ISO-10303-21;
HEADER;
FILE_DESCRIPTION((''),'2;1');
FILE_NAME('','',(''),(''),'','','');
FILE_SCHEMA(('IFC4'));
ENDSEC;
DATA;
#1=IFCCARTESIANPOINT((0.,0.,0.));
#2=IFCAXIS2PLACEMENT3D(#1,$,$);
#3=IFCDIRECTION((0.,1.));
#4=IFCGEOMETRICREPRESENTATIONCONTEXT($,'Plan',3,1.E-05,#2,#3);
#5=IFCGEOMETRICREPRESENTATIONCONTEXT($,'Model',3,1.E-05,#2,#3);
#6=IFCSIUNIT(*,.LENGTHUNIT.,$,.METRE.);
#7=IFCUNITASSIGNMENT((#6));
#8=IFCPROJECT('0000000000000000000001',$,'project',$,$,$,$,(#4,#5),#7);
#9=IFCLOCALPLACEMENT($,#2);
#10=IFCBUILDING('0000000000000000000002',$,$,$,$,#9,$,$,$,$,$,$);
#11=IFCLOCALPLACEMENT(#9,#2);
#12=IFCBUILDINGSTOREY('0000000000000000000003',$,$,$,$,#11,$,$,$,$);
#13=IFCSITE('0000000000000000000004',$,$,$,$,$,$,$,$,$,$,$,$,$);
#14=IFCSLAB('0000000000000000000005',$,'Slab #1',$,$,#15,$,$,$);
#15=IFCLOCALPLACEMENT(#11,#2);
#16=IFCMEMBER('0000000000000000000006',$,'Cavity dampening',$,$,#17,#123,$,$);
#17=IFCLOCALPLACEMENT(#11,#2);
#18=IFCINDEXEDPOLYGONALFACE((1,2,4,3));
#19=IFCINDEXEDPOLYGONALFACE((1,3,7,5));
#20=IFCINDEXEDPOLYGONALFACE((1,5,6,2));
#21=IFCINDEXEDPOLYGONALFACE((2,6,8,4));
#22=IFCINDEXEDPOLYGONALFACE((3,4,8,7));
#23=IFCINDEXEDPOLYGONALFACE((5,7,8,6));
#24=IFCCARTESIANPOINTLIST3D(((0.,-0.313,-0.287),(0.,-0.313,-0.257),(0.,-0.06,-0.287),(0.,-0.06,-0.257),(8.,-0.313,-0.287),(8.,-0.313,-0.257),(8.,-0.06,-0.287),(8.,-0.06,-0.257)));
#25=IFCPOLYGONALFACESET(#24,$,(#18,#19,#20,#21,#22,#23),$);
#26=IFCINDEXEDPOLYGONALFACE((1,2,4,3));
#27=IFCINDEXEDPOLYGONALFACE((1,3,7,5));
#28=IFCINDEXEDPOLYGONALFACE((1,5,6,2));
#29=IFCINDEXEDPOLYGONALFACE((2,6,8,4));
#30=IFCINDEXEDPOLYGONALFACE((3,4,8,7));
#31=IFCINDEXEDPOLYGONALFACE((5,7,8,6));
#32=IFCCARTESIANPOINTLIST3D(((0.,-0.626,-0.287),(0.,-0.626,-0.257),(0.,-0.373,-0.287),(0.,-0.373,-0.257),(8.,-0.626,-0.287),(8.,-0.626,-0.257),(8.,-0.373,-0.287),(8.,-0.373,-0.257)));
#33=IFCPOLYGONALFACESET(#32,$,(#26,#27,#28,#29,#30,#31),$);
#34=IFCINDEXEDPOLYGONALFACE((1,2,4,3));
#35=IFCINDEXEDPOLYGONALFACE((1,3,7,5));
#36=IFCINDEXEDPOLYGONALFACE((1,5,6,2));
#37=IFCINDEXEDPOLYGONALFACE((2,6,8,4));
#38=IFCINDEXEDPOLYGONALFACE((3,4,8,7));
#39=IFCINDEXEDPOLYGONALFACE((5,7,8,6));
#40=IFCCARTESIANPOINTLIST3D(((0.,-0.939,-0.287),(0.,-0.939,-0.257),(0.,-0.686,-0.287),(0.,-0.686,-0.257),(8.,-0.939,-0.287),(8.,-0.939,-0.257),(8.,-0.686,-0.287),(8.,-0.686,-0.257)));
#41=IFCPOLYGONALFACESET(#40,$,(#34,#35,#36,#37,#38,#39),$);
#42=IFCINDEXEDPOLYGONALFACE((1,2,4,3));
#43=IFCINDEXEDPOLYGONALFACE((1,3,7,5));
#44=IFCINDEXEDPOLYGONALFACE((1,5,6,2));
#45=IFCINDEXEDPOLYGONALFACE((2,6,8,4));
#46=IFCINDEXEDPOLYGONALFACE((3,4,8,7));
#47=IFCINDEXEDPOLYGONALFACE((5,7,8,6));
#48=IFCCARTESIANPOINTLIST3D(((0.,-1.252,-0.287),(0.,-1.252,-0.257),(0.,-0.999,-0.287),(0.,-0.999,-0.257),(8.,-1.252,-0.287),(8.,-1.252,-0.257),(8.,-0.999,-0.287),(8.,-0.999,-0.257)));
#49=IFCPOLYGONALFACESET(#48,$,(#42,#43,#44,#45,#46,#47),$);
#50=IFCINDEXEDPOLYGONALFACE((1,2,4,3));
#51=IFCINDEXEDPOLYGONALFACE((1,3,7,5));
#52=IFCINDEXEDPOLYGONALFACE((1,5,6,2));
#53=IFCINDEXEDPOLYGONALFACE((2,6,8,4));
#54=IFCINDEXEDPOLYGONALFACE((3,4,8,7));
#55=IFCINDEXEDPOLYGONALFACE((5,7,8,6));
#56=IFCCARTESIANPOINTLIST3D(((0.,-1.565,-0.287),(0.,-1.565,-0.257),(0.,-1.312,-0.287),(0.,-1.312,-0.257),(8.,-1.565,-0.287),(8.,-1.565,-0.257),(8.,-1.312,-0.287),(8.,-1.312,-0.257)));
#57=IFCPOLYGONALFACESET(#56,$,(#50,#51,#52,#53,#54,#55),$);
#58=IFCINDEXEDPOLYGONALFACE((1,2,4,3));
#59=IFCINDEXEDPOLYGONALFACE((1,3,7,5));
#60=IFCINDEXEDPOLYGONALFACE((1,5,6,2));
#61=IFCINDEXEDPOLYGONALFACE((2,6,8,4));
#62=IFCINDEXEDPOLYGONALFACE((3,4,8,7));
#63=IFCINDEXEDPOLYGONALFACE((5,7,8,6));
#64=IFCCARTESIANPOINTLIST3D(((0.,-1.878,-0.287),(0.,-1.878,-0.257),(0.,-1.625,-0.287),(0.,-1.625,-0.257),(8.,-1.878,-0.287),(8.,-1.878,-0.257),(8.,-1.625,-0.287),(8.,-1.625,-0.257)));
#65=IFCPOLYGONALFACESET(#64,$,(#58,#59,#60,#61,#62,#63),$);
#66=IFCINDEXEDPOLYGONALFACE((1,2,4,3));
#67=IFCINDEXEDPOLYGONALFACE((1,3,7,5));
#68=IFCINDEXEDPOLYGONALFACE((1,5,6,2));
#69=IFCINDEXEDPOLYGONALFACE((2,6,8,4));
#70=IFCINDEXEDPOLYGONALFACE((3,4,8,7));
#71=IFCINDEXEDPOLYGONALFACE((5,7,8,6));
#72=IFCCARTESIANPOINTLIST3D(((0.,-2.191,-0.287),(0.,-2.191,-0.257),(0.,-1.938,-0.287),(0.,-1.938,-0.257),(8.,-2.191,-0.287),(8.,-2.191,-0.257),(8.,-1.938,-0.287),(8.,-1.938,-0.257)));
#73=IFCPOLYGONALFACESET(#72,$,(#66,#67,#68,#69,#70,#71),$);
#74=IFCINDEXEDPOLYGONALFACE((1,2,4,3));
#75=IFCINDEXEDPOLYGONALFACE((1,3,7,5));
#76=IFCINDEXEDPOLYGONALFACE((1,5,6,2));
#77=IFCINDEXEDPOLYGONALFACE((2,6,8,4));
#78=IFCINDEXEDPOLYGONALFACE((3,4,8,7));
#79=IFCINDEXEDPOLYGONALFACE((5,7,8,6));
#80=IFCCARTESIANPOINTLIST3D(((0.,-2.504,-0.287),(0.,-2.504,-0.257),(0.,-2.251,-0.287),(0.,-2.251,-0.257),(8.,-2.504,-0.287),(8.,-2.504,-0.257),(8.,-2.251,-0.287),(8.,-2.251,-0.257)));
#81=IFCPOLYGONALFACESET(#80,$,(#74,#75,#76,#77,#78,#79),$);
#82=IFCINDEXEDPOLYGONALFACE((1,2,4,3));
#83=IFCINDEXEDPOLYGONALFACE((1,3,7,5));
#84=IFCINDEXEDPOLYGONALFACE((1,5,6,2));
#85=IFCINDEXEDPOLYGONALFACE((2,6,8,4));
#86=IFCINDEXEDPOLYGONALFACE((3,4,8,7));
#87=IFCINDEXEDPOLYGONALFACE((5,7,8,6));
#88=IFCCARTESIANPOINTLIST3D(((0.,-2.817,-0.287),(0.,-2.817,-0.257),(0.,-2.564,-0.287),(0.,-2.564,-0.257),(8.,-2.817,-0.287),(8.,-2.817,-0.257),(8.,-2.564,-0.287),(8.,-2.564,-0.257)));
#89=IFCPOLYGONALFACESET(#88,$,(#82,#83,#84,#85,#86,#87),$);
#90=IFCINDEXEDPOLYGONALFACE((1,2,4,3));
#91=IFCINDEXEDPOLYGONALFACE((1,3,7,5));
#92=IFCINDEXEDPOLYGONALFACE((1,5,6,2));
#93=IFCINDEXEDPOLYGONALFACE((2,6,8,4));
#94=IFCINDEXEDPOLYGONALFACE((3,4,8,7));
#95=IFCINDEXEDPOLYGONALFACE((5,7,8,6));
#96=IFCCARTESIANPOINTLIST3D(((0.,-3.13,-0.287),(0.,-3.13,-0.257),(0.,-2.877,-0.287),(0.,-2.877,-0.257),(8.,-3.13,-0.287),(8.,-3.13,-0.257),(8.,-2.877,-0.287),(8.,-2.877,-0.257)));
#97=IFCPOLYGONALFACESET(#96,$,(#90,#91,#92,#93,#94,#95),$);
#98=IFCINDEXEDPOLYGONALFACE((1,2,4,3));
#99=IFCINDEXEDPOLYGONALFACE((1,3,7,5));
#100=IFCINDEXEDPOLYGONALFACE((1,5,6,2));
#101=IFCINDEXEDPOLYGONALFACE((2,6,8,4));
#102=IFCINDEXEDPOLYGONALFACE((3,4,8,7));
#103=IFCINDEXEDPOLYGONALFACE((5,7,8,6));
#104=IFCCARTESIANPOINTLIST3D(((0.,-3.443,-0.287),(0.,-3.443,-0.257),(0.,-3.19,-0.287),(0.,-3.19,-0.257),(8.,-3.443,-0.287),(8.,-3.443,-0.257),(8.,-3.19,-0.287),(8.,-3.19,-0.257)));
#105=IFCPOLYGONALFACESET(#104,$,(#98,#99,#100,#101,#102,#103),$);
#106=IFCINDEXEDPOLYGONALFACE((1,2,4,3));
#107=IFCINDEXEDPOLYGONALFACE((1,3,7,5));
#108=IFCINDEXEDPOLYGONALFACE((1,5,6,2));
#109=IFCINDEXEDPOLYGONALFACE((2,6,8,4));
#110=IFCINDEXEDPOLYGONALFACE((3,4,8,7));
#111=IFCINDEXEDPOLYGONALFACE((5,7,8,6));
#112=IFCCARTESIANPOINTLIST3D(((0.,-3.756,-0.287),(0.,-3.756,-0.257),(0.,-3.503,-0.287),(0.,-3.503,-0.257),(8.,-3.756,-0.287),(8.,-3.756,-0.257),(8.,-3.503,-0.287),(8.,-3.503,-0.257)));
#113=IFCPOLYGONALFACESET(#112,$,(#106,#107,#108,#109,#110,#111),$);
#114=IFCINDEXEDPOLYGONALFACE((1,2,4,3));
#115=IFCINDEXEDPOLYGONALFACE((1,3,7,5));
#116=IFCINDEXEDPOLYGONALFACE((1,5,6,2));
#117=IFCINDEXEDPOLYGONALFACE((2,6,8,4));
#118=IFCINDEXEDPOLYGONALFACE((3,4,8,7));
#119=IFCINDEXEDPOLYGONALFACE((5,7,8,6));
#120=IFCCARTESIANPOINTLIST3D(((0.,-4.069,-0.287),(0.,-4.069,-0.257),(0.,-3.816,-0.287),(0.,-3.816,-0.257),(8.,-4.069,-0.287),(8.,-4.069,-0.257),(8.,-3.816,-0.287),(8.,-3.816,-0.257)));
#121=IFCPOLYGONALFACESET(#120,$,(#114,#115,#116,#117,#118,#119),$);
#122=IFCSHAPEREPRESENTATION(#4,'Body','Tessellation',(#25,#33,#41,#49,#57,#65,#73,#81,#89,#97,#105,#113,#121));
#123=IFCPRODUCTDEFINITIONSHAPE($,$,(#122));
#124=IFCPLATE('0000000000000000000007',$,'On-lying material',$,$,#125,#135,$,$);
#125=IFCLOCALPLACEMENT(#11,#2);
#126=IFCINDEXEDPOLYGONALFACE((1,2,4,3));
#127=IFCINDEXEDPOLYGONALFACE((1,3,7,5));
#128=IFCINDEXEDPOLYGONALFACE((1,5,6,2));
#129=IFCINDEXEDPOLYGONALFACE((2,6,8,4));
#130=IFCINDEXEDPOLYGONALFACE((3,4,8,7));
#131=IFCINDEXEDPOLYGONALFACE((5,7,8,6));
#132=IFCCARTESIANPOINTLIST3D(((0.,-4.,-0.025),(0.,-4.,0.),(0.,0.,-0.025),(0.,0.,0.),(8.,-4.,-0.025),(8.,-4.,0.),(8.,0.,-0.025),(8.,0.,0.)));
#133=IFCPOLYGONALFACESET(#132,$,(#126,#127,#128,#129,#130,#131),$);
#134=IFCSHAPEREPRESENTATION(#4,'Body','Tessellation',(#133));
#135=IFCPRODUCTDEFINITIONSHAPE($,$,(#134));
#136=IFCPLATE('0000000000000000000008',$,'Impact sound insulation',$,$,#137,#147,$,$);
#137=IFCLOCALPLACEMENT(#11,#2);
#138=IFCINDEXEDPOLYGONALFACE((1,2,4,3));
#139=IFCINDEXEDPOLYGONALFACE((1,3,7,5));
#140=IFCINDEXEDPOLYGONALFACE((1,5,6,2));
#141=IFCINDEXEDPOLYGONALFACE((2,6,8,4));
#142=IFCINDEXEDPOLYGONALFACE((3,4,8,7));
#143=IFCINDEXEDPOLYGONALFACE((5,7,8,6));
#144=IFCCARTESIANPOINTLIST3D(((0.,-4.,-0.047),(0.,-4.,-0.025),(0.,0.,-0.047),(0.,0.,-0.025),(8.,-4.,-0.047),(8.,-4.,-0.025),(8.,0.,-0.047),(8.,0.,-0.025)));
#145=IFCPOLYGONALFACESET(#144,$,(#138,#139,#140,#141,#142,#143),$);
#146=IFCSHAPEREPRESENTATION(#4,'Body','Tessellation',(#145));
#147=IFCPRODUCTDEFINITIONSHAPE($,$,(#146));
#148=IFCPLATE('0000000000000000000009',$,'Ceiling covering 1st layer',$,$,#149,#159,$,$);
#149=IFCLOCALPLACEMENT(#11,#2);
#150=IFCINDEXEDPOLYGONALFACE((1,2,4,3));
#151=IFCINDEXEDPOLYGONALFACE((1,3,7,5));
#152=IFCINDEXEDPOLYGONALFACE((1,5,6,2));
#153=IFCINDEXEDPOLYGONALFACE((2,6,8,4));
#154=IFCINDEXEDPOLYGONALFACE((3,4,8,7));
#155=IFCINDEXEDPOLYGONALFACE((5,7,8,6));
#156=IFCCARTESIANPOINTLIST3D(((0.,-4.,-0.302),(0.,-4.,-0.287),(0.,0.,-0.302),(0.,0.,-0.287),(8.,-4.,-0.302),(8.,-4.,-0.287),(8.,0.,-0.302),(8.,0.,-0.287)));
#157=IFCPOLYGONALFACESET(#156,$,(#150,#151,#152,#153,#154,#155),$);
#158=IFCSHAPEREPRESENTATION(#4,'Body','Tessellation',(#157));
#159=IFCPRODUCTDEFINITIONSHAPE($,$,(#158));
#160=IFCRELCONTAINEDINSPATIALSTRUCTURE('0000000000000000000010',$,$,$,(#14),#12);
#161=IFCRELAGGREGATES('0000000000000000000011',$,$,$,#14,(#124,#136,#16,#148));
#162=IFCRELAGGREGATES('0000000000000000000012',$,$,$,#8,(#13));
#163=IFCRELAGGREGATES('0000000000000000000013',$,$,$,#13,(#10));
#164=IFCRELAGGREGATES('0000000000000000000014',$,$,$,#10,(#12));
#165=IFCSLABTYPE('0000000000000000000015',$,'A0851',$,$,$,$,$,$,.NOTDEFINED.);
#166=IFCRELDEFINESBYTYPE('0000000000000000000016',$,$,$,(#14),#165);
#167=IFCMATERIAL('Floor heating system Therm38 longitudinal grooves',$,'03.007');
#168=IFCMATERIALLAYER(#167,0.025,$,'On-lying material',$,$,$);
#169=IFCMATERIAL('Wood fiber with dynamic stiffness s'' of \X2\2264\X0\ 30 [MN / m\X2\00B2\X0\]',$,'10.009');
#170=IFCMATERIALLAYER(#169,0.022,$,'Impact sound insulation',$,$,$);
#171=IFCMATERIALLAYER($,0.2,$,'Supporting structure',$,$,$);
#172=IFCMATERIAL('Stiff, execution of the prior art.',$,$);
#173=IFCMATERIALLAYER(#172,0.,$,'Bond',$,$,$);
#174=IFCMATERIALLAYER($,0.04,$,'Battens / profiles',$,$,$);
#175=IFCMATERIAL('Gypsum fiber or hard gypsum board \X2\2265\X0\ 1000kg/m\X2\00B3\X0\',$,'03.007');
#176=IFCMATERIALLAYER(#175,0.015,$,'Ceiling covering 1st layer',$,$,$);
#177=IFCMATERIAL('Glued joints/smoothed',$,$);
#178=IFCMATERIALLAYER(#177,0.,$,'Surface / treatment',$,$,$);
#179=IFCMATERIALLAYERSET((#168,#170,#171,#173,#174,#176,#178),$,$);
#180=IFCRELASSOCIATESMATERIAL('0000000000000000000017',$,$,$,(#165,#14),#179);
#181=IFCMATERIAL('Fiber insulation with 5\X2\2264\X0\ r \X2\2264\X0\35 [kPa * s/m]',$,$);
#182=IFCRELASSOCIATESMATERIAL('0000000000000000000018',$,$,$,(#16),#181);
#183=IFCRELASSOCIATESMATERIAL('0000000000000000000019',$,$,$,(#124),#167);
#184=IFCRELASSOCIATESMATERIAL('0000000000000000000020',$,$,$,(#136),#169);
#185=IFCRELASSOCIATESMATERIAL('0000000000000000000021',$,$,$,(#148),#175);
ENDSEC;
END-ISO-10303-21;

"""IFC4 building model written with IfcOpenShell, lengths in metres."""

from ifc_helpers import new_model, si_unit, direction, frame, frame_2d, origin, origin_with_axes, place, context, project, spatial, rectangle, extrude, material, layer, layer_set, type_object, element, aggregate, save


model = new_model("IFC4")

# Units and contexts
plan_context = context("Plan", 3, precision=1e-05, world=origin(), true_north=direction((0.0, 1.0)))
model_context = context("Model", 3, precision=1e-05, world=origin(), true_north=direction((0.0, 1.0)))
ifc_project = project(units=[si_unit("LENGTHUNIT", "METRE")], contexts=[plan_context, model_context])

# Site, building, storey
site = spatial("IfcSite", under=ifc_project)
building_placement = place(None, origin())
building = spatial("IfcBuilding", under=site, at=building_placement)
storey_placement = place(building_placement, origin())
storey = spatial("IfcBuildingStorey", under=building, at=storey_placement)

# Slab, member, plates
ifc_material_1 = material(Name="Floor heating system Therm38 longitudinal grooves", Category="03.007")
ifc_layer_1 = layer(ifc_material_1, 0.025, Name="On-lying material")
ifc_material_2 = material(Name="Wood fiber with dynamic stiffness s' of ≤ 30 [MN / m²]", Category="10.009")
ifc_layer_2 = layer(ifc_material_2, 0.022, Name="Impact sound insulation")
ifc_layer_3 = layer(None, 0.2, Name="Supporting structure")
ifc_material_3 = material(Name="Stiff, execution of the prior art.")
ifc_layer_4 = layer(ifc_material_3, 0.0, Name="Bond")
ifc_layer_5 = layer(None, 0.04, Name="Battens / profiles")
ifc_material_4 = material(Name="Gypsum fiber or hard gypsum board ≥ 1000kg/m³", Category="03.007")
ifc_layer_6 = layer(ifc_material_4, 0.015, Name="Ceiling covering 1st layer")
ifc_material_5 = material(Name="Glued joints/smoothed")
ifc_layer_7 = layer(ifc_material_5, 0.0, Name="Surface / treatment")
ifc_layer_set = layer_set([ifc_layer_1, ifc_layer_2, ifc_layer_3, ifc_layer_4, ifc_layer_5, ifc_layer_6, ifc_layer_7])
slab_type = type_object("IfcSlabType", Name="A0851", PredefinedType="NOTDEFINED", material=ifc_layer_set)
slab_placement = place(None, frame((0.0, 0.0, 0.0), z_axis=(0.0, 0.0, -1.0), x_axis=(1.0, 0.0, 0.0)))
slab = element("IfcSlab", 1, at=slab_placement, inside=storey, type_object=slab_type, material=ifc_layer_set, Name="Slab #1")
ifc_material_6 = material(Name="Fiber insulation with 5≤ r ≤35 [kPa * s/m]")
member_1_placement = place(slab_placement, origin())
member_1 = element("IfcMember", 2, at=member_1_placement, material=ifc_material_6, Name="Cavity dampening", context=plan_context, shape_type="SweptSolid", body=[
    extrude(rectangle(XDim=0.253, YDim=0.03, at=frame_2d((0.1265, 0.015), x_axis=(1.0, 0.0))), frame((0.0, 0.06, 0.257), z_axis=(1.0, 0.0, 0.0), x_axis=(0.0, 1.0, 0.0)), (0.0, 0.0, 1.0), 8.0),
    extrude(rectangle(XDim=0.253, YDim=0.03, at=frame_2d((0.1265, 0.015), x_axis=(1.0, 0.0))), frame((0.0, 0.373, 0.257), z_axis=(1.0, 0.0, 0.0), x_axis=(0.0, 1.0, 0.0)), (0.0, 0.0, 1.0), 8.0),
    extrude(rectangle(XDim=0.253, YDim=0.03, at=frame_2d((0.1265, 0.015), x_axis=(1.0, 0.0))), frame((0.0, 0.686, 0.257), z_axis=(1.0, 0.0, 0.0), x_axis=(0.0, 1.0, 0.0)), (0.0, 0.0, 1.0), 8.0),
    extrude(rectangle(XDim=0.253, YDim=0.03, at=frame_2d((0.1265, 0.015), x_axis=(1.0, 0.0))), frame((0.0, 0.999, 0.257), z_axis=(1.0, 0.0, 0.0), x_axis=(0.0, 1.0, 0.0)), (0.0, 0.0, 1.0), 8.0),
    extrude(rectangle(XDim=0.253, YDim=0.03, at=frame_2d((0.1265, 0.015), x_axis=(1.0, 0.0))), frame((0.0, 1.312, 0.257), z_axis=(1.0, 0.0, 0.0), x_axis=(0.0, 1.0, 0.0)), (0.0, 0.0, 1.0), 8.0),
    extrude(rectangle(XDim=0.253, YDim=0.03, at=frame_2d((0.1265, 0.015), x_axis=(1.0, 0.0))), frame((0.0, 1.625, 0.257), z_axis=(1.0, 0.0, 0.0), x_axis=(0.0, 1.0, 0.0)), (0.0, 0.0, 1.0), 8.0),
    extrude(rectangle(XDim=0.253, YDim=0.03, at=frame_2d((0.1265, 0.015), x_axis=(1.0, 0.0))), frame((0.0, 1.938, 0.257), z_axis=(1.0, 0.0, 0.0), x_axis=(0.0, 1.0, 0.0)), (0.0, 0.0, 1.0), 8.0),
    extrude(rectangle(XDim=0.253, YDim=0.03, at=frame_2d((0.1265, 0.015), x_axis=(1.0, 0.0))), frame((0.0, 2.251, 0.257), z_axis=(1.0, 0.0, 0.0), x_axis=(0.0, 1.0, 0.0)), (0.0, 0.0, 1.0), 8.0),
    extrude(rectangle(XDim=0.253, YDim=0.03, at=frame_2d((0.1265, 0.015), x_axis=(1.0, 0.0))), frame((0.0, 2.564, 0.257), z_axis=(1.0, 0.0, 0.0), x_axis=(0.0, 1.0, 0.0)), (0.0, 0.0, 1.0), 8.0),
    extrude(rectangle(XDim=0.253, YDim=0.03, at=frame_2d((0.1265, 0.015), x_axis=(1.0, 0.0))), frame((0.0, 2.877, 0.257), z_axis=(1.0, 0.0, 0.0), x_axis=(0.0, 1.0, 0.0)), (0.0, 0.0, 1.0), 8.0),
    extrude(rectangle(XDim=0.253, YDim=0.03, at=frame_2d((0.1265, 0.015), x_axis=(1.0, 0.0))), frame((0.0, 3.19, 0.257), z_axis=(1.0, 0.0, 0.0), x_axis=(0.0, 1.0, 0.0)), (0.0, 0.0, 1.0), 8.0),
    extrude(rectangle(XDim=0.253, YDim=0.03, at=frame_2d((0.1265, 0.015), x_axis=(1.0, 0.0))), frame((0.0, 3.503, 0.257), z_axis=(1.0, 0.0, 0.0), x_axis=(0.0, 1.0, 0.0)), (0.0, 0.0, 1.0), 8.0),
    extrude(rectangle(XDim=0.253, YDim=0.03, at=frame_2d((0.1265, 0.015), x_axis=(1.0, 0.0))), frame((0.0, 3.816, 0.257), z_axis=(1.0, 0.0, 0.0), x_axis=(0.0, 1.0, 0.0)), (0.0, 0.0, 1.0), 8.0),
])
plate_1_placement = place(slab_placement, origin())
plate_1 = element("IfcPlate", 3, at=plate_1_placement, material=ifc_material_1, Name="On-lying material", context=plan_context, shape_type="SweptSolid", body=[
    extrude(rectangle(XDim=8.0, YDim=4.0, at=frame_2d((4.0, 2.0), x_axis=(1.0, 0.0))), origin_with_axes(), (0.0, 0.0, 1.0), 0.025),
])
plate_2_placement = place(slab_placement, origin())
plate_2 = element("IfcPlate", 4, at=plate_2_placement, material=ifc_material_2, Name="Impact sound insulation", context=plan_context, shape_type="SweptSolid", body=[
    extrude(rectangle(XDim=8.0, YDim=4.0, at=frame_2d((4.0, 2.0), x_axis=(1.0, 0.0))), frame((0.0, 0.0, 0.025), z_axis=(0.0, 0.0, 1.0), x_axis=(1.0, 0.0, 0.0)), (0.0, 0.0, 1.0), 0.022),
])
plate_3_placement = place(slab_placement, origin())
plate_3 = element("IfcPlate", 5, at=plate_3_placement, material=ifc_material_4, Name="Ceiling covering 1st layer", context=plan_context, shape_type="SweptSolid", body=[
    extrude(rectangle(XDim=8.0, YDim=4.0, at=frame_2d((4.0, 2.0), x_axis=(1.0, 0.0))), frame((0.0, 0.0, 0.287), z_axis=(0.0, 0.0, 1.0), x_axis=(1.0, 0.0, 0.0)), (0.0, 0.0, 1.0), 0.015),
])
aggregate(slab, [plate_1, plate_2, member_1, plate_3])

save(model, "model.ifc")
